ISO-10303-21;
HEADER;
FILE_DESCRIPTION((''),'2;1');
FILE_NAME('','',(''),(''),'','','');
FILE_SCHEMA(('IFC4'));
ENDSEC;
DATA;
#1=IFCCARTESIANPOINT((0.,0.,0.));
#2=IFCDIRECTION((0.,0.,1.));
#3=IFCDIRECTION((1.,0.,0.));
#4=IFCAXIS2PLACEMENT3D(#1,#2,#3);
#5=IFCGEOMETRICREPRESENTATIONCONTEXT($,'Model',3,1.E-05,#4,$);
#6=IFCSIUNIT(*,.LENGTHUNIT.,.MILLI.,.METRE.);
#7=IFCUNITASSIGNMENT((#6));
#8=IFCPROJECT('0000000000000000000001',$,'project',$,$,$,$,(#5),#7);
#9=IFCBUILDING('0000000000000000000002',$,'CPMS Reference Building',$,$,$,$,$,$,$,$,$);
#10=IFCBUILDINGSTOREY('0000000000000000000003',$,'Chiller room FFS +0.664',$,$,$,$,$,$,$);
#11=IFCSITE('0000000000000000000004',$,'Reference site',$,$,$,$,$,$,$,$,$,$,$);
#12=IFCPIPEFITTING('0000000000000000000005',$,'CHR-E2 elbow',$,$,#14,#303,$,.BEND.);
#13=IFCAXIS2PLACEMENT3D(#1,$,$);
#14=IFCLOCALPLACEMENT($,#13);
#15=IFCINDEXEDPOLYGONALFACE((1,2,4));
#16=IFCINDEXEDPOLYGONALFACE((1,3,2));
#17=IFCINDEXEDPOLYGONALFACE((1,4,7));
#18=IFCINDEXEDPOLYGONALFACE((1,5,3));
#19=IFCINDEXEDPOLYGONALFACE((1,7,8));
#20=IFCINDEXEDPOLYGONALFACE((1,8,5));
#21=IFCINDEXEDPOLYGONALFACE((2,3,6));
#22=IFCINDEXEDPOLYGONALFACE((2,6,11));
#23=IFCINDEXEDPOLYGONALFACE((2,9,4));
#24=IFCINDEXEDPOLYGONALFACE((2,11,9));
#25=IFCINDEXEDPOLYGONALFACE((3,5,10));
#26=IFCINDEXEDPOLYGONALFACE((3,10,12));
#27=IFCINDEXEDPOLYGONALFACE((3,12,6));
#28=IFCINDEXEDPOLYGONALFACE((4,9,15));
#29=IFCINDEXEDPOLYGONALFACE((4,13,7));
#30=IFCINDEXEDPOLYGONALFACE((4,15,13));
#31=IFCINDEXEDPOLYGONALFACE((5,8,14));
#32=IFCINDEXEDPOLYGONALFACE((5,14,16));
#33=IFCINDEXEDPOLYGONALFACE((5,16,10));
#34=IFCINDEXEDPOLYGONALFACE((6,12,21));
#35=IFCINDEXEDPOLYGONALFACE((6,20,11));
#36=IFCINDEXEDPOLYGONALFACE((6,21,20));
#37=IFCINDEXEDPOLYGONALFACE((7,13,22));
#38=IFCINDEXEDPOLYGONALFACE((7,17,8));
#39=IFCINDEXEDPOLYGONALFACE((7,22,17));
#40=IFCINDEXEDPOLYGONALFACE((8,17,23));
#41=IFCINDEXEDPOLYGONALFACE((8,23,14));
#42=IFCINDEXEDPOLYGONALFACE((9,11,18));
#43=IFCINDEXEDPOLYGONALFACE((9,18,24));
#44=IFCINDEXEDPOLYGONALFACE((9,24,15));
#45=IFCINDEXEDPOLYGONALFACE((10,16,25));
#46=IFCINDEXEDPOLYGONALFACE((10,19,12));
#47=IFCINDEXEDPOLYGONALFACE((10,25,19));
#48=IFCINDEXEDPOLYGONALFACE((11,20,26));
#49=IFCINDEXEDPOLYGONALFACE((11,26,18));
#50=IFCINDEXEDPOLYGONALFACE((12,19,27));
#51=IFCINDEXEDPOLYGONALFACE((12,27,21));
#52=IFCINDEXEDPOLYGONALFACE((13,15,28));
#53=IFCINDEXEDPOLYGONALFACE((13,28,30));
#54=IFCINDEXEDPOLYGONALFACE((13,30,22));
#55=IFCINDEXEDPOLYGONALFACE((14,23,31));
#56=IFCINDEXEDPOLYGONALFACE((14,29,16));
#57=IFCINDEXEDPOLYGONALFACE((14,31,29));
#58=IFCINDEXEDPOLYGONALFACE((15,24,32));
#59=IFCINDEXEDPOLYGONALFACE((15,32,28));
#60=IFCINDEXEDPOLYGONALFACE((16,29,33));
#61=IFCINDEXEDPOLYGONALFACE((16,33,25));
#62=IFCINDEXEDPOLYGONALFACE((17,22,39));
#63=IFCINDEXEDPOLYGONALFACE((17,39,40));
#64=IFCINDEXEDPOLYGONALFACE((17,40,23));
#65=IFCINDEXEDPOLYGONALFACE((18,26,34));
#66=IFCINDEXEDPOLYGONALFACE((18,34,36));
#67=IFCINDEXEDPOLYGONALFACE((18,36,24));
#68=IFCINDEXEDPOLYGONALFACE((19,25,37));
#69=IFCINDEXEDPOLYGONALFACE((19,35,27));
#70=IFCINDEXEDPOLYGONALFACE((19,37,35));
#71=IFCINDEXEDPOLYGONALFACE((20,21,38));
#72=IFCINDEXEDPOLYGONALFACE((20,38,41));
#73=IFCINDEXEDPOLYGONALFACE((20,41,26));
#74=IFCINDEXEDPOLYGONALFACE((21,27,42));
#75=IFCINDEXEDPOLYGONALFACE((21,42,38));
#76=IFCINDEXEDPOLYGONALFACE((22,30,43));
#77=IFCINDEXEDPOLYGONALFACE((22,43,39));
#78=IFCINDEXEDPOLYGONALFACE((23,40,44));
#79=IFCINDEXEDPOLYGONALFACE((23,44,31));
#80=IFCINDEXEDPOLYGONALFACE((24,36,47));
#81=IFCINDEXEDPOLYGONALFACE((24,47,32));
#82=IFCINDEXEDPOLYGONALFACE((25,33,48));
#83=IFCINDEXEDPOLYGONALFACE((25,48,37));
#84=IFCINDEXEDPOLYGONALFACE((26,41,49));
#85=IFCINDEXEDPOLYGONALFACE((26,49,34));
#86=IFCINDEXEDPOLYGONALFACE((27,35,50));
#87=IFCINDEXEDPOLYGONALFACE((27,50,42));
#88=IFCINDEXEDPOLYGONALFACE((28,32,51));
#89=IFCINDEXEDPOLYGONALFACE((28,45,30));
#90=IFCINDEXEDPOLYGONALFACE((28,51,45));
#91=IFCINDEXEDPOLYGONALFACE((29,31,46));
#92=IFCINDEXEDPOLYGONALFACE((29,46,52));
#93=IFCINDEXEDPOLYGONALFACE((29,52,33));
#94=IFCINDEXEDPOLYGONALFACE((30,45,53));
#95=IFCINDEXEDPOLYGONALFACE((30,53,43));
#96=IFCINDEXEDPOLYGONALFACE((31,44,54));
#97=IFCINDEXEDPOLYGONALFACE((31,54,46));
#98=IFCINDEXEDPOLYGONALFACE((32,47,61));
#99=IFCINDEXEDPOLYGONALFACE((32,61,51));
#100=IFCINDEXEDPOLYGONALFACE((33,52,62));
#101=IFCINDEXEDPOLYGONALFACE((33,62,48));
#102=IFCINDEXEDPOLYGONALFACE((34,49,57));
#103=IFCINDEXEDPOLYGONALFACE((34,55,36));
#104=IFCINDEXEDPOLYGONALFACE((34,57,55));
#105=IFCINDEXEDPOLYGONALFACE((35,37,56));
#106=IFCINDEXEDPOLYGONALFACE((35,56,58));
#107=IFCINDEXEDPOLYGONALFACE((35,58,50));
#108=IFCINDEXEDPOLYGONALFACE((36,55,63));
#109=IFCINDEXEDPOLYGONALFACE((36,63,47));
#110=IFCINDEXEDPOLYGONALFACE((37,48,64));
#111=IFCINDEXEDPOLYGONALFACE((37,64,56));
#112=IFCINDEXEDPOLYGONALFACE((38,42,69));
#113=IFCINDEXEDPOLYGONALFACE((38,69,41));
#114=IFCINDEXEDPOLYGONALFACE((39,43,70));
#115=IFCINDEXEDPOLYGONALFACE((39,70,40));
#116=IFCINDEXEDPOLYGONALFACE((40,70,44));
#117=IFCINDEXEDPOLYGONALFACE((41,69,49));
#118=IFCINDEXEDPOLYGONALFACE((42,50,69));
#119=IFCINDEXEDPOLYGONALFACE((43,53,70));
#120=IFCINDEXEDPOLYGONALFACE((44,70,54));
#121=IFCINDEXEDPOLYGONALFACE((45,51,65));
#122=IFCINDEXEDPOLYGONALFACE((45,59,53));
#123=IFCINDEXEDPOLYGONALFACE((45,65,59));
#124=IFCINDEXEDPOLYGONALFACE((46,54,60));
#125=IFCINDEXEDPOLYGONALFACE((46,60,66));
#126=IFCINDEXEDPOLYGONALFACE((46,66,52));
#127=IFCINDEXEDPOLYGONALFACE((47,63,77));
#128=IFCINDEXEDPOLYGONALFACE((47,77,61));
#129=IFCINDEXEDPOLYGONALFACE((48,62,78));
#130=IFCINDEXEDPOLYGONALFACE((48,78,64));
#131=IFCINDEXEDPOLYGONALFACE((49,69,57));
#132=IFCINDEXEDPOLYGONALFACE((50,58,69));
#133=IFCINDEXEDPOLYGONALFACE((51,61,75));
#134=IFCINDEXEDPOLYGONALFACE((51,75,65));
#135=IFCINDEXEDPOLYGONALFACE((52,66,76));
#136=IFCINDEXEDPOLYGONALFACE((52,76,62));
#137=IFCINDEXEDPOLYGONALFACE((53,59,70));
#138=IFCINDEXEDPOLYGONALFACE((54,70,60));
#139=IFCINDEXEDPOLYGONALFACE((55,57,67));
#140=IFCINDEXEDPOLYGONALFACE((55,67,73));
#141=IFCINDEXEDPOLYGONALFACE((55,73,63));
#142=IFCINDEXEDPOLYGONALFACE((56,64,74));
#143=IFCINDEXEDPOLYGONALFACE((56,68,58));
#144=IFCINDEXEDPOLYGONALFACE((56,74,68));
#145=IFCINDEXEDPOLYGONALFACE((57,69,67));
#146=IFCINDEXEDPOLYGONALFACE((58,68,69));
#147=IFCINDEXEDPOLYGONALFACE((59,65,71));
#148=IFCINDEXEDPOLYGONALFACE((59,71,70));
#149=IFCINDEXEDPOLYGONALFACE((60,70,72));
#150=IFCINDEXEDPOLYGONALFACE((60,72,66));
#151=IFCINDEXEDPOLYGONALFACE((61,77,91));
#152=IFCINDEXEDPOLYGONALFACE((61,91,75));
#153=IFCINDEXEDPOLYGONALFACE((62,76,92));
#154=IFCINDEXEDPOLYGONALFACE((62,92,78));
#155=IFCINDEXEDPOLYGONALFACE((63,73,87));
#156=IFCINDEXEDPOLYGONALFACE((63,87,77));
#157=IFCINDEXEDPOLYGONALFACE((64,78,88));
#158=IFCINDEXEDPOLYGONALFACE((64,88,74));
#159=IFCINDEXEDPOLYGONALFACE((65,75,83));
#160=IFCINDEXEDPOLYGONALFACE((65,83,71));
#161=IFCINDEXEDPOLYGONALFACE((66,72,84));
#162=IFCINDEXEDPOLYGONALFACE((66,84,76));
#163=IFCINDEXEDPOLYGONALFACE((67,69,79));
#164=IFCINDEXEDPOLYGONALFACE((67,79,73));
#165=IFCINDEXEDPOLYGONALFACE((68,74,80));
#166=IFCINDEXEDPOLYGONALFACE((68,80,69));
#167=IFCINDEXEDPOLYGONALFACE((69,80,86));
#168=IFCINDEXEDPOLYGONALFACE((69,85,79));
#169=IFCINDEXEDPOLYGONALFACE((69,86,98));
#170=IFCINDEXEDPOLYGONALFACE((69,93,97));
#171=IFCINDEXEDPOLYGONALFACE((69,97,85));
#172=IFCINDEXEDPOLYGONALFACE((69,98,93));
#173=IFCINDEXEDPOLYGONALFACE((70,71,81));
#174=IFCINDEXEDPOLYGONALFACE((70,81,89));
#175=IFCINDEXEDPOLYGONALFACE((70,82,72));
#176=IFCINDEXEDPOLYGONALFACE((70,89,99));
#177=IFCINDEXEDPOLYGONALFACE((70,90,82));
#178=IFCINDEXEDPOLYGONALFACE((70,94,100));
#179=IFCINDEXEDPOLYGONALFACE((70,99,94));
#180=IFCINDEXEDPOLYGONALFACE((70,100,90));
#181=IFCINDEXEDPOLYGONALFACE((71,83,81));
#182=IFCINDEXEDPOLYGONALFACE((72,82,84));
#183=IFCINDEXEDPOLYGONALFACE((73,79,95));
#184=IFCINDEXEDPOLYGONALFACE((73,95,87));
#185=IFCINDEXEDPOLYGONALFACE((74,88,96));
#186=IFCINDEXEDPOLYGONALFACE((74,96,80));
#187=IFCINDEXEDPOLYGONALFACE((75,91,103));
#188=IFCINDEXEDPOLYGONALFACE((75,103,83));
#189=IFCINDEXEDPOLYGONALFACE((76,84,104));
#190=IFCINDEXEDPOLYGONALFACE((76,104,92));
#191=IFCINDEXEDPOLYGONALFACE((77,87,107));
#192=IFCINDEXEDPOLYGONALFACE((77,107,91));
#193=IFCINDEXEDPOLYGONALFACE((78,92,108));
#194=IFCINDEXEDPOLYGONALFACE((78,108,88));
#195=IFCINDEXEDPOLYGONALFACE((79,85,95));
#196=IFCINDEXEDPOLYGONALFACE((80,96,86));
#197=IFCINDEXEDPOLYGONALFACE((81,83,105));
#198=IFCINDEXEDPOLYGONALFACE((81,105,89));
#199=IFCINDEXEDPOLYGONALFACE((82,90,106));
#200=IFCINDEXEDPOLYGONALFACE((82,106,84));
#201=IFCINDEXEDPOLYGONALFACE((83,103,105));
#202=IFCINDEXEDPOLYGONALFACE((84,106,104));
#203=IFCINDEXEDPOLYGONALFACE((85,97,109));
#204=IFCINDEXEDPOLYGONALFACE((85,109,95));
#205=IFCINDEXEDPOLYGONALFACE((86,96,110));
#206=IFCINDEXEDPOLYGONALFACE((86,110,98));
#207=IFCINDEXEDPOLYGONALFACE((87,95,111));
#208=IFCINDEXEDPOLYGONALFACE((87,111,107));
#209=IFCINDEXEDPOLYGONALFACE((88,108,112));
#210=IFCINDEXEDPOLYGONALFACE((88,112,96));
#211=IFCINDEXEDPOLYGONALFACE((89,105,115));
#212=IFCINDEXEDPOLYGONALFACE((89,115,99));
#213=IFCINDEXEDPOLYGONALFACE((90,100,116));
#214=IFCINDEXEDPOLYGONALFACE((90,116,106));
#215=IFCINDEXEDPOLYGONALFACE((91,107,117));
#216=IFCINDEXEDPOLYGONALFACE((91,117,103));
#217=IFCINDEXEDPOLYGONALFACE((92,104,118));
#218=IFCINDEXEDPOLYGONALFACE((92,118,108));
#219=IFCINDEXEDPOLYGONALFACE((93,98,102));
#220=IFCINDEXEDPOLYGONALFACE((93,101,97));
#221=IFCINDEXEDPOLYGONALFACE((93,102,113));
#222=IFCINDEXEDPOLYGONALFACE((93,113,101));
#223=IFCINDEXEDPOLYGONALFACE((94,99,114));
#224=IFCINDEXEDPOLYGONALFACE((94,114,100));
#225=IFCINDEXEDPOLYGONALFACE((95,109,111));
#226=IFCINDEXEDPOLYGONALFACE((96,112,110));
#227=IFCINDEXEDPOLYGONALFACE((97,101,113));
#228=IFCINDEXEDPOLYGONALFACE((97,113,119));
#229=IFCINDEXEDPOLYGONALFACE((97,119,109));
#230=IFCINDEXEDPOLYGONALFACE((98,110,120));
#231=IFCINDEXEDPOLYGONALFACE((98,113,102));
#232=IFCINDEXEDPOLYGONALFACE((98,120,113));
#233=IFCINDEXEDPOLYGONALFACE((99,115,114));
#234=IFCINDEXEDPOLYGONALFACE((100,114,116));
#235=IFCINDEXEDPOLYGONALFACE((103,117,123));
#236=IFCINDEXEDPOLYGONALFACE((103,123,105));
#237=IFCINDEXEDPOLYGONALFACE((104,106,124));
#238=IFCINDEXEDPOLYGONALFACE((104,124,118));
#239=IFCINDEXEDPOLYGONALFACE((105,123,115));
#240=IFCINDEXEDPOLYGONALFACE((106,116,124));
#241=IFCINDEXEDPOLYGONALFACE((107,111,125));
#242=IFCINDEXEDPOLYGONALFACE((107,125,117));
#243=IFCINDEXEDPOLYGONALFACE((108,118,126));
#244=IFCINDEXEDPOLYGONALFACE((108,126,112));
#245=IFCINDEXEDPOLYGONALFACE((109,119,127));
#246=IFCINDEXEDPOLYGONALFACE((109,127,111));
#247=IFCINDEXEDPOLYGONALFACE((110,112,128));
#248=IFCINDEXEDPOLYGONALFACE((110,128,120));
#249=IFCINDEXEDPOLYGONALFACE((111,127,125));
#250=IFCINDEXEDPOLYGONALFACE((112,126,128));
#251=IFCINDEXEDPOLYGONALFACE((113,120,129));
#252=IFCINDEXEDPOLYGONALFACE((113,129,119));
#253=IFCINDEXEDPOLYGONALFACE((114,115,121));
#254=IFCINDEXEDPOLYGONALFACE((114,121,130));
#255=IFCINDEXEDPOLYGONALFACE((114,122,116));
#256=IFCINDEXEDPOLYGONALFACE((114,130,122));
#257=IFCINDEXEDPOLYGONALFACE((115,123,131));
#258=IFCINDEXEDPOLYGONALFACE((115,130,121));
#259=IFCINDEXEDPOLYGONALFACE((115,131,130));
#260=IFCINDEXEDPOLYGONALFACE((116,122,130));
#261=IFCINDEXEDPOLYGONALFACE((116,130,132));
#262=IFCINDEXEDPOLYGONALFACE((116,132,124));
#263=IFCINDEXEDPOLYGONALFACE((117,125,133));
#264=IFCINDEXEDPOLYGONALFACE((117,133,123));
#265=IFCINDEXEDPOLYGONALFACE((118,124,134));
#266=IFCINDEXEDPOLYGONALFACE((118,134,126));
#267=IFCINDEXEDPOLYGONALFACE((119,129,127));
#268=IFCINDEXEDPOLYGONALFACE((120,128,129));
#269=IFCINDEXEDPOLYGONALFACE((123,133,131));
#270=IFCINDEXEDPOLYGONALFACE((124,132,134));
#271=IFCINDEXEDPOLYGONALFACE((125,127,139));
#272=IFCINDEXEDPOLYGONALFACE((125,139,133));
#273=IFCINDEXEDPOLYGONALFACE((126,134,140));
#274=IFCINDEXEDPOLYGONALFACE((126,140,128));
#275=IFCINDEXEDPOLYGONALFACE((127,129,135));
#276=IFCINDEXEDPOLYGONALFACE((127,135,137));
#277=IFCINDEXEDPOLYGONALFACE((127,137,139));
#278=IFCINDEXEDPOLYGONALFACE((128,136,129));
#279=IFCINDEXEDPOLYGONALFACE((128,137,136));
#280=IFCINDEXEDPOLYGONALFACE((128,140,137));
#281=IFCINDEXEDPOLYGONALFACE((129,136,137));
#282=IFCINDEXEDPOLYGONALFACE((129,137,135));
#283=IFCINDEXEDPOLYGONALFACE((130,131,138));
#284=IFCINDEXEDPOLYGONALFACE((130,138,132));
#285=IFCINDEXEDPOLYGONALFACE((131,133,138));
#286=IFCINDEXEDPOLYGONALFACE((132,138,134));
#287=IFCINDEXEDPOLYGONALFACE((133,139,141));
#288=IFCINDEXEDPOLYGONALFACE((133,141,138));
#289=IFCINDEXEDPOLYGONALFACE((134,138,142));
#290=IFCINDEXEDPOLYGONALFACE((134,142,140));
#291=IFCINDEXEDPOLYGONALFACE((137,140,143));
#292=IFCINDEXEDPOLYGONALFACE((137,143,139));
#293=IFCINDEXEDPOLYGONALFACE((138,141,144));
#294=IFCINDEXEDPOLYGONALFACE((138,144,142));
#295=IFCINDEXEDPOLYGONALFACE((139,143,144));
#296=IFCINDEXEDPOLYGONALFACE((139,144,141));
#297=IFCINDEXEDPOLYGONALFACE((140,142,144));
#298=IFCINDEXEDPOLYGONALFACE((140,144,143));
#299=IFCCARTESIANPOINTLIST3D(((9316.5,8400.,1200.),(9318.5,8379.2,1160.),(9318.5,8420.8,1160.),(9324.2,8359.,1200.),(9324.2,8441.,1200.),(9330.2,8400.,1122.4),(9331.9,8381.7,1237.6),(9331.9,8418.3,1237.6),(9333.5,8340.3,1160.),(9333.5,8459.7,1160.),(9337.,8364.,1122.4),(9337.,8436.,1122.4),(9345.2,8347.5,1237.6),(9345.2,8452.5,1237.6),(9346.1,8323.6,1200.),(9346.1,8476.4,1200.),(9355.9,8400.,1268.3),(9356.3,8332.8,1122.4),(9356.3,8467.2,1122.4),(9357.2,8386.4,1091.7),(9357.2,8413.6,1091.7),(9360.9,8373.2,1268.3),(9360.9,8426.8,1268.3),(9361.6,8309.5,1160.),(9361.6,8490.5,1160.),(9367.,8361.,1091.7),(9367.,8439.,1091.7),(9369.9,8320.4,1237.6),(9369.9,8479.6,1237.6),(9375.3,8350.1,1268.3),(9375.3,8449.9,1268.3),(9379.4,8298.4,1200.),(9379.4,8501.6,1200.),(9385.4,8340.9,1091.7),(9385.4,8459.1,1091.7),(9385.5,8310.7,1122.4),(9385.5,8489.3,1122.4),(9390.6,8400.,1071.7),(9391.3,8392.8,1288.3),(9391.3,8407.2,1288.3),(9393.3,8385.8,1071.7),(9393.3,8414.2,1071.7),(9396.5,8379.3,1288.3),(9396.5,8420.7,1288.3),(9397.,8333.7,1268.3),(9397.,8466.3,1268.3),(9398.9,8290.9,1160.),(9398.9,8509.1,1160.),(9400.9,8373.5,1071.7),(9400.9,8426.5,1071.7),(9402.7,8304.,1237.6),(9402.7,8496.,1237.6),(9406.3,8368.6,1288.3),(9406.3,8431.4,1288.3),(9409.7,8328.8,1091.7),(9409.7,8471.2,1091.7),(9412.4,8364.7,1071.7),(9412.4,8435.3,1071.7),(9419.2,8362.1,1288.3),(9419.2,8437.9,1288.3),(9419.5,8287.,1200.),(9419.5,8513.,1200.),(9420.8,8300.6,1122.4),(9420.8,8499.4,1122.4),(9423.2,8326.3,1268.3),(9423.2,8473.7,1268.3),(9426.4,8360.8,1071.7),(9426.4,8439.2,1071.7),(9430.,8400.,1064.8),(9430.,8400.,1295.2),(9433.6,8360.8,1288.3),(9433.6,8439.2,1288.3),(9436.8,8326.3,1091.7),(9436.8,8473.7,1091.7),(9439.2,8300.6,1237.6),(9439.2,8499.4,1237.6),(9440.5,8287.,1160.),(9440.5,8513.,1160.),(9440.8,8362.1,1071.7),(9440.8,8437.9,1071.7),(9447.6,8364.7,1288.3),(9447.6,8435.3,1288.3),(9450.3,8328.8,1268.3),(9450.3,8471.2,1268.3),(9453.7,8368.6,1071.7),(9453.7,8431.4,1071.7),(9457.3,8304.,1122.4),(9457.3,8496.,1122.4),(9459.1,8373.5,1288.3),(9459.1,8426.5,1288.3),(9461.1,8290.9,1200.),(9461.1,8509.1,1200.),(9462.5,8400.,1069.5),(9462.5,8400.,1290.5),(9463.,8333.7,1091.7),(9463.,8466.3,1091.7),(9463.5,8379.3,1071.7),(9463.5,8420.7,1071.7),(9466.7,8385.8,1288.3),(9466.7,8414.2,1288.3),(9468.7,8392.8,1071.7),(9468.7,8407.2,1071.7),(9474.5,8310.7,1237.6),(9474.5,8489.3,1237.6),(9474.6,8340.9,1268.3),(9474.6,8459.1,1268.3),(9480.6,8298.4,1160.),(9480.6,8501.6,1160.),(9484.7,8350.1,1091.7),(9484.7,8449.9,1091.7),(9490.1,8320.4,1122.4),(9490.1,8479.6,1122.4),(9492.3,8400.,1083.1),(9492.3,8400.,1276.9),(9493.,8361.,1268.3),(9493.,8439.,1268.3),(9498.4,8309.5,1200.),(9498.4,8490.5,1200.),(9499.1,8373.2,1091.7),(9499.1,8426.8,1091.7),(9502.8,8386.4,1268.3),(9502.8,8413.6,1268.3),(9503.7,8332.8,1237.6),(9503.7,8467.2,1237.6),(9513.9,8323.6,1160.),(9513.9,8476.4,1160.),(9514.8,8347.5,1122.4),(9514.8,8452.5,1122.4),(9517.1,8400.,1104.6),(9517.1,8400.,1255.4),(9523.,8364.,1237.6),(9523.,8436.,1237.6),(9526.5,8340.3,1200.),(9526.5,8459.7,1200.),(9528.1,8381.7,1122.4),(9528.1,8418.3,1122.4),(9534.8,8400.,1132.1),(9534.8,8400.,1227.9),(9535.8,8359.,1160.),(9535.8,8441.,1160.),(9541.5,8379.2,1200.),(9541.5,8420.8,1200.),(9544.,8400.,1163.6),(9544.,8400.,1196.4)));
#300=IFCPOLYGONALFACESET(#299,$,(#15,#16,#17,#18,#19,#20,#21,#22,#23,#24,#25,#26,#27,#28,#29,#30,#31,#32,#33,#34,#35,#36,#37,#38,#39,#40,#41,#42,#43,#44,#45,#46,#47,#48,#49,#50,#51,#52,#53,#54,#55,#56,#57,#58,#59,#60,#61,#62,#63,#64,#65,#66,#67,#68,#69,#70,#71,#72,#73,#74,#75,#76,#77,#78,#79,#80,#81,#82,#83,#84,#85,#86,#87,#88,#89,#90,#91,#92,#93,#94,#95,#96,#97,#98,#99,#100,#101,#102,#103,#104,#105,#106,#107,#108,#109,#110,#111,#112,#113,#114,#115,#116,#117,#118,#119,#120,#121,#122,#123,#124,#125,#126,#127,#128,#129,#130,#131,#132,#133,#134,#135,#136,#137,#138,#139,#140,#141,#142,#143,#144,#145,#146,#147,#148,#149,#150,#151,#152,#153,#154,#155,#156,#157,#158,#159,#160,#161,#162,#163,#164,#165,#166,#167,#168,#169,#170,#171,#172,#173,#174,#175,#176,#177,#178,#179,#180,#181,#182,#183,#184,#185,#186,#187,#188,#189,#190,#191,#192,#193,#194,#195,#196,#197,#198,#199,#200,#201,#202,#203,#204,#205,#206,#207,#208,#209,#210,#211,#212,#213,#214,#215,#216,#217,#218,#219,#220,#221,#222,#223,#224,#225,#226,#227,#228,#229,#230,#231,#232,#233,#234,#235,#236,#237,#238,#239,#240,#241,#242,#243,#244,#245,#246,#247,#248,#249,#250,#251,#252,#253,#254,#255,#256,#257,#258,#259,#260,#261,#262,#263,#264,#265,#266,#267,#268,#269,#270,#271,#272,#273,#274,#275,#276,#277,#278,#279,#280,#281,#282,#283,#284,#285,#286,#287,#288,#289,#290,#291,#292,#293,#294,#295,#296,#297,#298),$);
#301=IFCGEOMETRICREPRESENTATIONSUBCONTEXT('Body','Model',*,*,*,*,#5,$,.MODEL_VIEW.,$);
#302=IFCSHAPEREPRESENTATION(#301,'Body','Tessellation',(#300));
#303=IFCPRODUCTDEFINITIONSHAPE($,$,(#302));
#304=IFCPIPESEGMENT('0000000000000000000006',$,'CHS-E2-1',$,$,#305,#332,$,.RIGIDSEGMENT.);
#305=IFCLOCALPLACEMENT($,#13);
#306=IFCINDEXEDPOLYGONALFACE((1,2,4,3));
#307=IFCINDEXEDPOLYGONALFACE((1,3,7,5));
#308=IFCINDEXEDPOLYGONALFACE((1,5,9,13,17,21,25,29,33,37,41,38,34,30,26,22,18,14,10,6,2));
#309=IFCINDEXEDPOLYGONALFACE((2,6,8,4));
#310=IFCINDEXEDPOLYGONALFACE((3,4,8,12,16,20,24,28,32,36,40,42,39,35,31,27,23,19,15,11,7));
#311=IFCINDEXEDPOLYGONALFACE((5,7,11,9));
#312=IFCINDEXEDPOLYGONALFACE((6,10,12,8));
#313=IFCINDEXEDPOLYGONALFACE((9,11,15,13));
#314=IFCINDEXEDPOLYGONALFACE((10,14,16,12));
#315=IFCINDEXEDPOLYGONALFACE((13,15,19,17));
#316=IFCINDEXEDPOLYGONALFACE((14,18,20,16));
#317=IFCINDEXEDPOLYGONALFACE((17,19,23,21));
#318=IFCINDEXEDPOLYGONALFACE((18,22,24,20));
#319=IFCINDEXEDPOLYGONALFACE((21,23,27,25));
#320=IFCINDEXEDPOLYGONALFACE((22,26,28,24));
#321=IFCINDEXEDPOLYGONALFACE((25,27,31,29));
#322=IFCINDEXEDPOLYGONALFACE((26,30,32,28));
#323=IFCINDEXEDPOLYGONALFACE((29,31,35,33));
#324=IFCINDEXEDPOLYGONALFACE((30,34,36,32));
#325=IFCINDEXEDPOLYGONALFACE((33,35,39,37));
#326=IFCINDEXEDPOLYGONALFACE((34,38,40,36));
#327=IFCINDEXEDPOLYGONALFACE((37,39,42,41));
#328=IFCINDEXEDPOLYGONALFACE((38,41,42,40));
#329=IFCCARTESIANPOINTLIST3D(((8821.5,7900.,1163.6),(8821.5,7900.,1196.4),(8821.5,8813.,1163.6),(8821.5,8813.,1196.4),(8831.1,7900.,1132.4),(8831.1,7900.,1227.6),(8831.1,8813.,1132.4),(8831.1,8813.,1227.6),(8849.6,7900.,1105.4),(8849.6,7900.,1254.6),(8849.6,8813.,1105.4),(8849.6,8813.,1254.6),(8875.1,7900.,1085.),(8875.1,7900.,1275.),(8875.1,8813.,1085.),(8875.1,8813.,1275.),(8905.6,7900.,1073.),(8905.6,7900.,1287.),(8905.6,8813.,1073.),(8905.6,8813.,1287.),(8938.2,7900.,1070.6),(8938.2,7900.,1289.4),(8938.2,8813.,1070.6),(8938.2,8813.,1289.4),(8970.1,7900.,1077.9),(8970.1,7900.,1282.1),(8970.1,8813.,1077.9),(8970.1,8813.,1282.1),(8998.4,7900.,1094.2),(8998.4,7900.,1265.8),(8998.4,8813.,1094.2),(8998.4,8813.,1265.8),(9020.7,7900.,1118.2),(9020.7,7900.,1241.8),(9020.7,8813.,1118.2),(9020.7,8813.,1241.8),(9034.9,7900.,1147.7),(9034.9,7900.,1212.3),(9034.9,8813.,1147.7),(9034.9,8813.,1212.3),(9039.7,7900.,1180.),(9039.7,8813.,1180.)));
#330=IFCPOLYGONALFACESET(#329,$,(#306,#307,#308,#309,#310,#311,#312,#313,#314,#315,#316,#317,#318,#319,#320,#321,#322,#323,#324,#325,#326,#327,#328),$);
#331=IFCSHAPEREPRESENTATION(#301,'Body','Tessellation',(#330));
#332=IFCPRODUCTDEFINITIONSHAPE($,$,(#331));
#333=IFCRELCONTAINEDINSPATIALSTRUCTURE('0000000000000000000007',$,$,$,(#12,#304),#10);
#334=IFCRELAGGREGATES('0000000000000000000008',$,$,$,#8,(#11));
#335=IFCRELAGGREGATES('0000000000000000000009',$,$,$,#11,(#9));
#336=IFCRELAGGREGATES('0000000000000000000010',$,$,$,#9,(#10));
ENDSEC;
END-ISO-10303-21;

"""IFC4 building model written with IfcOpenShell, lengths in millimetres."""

from ifc_helpers import new_model, entity, si_unit, frame, origin_with_axes, origin_2d, place, context, subcontext, project, spatial, circle_curve, outline, extrude, element, save


model = new_model("IFC4")

# Units and contexts
model_context = context("Model", 3, precision=1e-05, world=origin_with_axes())
body_context = subcontext(model_context, "Body", "Model", "MODEL_VIEW")
ifc_project = project(units=[si_unit("LENGTHUNIT", "METRE", prefix="MILLI")], contexts=[model_context])

# Site, building, storey
site = spatial("IfcSite", under=ifc_project, Name="Reference site")
building = spatial("IfcBuilding", under=site, Name="CPMS Reference Building")
storey = spatial("IfcBuildingStorey", under=building, Name="Chiller room FFS +0.664")

# Pipe fitting
pipe_fitting_1_placement = place(None, origin_with_axes())
element("IfcPipeFitting", 1, at=pipe_fitting_1_placement, inside=storey, Name="CHR-E2 elbow", PredefinedType="BEND", context=body_context, shape_type="CSG", body=[
    entity("IfcSphere", entity("IfcAxis2Placement3D", entity("IfcCartesianPoint", [9430.0, 8400.0, 1180.0]), entity("IfcDirection", [0.0, 0.0, 1.0]), entity("IfcDirection", [1.0, 0.0, 0.0])), 115.2),
])

# Pipe segment
pipe_segment_1_placement = place(None, origin_with_axes())
element("IfcPipeSegment", 2, at=pipe_segment_1_placement, inside=storey, Name="CHS-E2-1", PredefinedType="RIGIDSEGMENT", context=body_context, shape_type="SweptSolid", body=[
    extrude(outline(circle_curve(origin_2d(), 109.7)), frame((8930.0, 8813.0, 1180.0), z_axis=(0.0, -1.0, 0.0), x_axis=(1.0, 0.0, 0.0)), (0.0, 0.0, 1.0), 913.0),
])

save(model, "model.ifc")
